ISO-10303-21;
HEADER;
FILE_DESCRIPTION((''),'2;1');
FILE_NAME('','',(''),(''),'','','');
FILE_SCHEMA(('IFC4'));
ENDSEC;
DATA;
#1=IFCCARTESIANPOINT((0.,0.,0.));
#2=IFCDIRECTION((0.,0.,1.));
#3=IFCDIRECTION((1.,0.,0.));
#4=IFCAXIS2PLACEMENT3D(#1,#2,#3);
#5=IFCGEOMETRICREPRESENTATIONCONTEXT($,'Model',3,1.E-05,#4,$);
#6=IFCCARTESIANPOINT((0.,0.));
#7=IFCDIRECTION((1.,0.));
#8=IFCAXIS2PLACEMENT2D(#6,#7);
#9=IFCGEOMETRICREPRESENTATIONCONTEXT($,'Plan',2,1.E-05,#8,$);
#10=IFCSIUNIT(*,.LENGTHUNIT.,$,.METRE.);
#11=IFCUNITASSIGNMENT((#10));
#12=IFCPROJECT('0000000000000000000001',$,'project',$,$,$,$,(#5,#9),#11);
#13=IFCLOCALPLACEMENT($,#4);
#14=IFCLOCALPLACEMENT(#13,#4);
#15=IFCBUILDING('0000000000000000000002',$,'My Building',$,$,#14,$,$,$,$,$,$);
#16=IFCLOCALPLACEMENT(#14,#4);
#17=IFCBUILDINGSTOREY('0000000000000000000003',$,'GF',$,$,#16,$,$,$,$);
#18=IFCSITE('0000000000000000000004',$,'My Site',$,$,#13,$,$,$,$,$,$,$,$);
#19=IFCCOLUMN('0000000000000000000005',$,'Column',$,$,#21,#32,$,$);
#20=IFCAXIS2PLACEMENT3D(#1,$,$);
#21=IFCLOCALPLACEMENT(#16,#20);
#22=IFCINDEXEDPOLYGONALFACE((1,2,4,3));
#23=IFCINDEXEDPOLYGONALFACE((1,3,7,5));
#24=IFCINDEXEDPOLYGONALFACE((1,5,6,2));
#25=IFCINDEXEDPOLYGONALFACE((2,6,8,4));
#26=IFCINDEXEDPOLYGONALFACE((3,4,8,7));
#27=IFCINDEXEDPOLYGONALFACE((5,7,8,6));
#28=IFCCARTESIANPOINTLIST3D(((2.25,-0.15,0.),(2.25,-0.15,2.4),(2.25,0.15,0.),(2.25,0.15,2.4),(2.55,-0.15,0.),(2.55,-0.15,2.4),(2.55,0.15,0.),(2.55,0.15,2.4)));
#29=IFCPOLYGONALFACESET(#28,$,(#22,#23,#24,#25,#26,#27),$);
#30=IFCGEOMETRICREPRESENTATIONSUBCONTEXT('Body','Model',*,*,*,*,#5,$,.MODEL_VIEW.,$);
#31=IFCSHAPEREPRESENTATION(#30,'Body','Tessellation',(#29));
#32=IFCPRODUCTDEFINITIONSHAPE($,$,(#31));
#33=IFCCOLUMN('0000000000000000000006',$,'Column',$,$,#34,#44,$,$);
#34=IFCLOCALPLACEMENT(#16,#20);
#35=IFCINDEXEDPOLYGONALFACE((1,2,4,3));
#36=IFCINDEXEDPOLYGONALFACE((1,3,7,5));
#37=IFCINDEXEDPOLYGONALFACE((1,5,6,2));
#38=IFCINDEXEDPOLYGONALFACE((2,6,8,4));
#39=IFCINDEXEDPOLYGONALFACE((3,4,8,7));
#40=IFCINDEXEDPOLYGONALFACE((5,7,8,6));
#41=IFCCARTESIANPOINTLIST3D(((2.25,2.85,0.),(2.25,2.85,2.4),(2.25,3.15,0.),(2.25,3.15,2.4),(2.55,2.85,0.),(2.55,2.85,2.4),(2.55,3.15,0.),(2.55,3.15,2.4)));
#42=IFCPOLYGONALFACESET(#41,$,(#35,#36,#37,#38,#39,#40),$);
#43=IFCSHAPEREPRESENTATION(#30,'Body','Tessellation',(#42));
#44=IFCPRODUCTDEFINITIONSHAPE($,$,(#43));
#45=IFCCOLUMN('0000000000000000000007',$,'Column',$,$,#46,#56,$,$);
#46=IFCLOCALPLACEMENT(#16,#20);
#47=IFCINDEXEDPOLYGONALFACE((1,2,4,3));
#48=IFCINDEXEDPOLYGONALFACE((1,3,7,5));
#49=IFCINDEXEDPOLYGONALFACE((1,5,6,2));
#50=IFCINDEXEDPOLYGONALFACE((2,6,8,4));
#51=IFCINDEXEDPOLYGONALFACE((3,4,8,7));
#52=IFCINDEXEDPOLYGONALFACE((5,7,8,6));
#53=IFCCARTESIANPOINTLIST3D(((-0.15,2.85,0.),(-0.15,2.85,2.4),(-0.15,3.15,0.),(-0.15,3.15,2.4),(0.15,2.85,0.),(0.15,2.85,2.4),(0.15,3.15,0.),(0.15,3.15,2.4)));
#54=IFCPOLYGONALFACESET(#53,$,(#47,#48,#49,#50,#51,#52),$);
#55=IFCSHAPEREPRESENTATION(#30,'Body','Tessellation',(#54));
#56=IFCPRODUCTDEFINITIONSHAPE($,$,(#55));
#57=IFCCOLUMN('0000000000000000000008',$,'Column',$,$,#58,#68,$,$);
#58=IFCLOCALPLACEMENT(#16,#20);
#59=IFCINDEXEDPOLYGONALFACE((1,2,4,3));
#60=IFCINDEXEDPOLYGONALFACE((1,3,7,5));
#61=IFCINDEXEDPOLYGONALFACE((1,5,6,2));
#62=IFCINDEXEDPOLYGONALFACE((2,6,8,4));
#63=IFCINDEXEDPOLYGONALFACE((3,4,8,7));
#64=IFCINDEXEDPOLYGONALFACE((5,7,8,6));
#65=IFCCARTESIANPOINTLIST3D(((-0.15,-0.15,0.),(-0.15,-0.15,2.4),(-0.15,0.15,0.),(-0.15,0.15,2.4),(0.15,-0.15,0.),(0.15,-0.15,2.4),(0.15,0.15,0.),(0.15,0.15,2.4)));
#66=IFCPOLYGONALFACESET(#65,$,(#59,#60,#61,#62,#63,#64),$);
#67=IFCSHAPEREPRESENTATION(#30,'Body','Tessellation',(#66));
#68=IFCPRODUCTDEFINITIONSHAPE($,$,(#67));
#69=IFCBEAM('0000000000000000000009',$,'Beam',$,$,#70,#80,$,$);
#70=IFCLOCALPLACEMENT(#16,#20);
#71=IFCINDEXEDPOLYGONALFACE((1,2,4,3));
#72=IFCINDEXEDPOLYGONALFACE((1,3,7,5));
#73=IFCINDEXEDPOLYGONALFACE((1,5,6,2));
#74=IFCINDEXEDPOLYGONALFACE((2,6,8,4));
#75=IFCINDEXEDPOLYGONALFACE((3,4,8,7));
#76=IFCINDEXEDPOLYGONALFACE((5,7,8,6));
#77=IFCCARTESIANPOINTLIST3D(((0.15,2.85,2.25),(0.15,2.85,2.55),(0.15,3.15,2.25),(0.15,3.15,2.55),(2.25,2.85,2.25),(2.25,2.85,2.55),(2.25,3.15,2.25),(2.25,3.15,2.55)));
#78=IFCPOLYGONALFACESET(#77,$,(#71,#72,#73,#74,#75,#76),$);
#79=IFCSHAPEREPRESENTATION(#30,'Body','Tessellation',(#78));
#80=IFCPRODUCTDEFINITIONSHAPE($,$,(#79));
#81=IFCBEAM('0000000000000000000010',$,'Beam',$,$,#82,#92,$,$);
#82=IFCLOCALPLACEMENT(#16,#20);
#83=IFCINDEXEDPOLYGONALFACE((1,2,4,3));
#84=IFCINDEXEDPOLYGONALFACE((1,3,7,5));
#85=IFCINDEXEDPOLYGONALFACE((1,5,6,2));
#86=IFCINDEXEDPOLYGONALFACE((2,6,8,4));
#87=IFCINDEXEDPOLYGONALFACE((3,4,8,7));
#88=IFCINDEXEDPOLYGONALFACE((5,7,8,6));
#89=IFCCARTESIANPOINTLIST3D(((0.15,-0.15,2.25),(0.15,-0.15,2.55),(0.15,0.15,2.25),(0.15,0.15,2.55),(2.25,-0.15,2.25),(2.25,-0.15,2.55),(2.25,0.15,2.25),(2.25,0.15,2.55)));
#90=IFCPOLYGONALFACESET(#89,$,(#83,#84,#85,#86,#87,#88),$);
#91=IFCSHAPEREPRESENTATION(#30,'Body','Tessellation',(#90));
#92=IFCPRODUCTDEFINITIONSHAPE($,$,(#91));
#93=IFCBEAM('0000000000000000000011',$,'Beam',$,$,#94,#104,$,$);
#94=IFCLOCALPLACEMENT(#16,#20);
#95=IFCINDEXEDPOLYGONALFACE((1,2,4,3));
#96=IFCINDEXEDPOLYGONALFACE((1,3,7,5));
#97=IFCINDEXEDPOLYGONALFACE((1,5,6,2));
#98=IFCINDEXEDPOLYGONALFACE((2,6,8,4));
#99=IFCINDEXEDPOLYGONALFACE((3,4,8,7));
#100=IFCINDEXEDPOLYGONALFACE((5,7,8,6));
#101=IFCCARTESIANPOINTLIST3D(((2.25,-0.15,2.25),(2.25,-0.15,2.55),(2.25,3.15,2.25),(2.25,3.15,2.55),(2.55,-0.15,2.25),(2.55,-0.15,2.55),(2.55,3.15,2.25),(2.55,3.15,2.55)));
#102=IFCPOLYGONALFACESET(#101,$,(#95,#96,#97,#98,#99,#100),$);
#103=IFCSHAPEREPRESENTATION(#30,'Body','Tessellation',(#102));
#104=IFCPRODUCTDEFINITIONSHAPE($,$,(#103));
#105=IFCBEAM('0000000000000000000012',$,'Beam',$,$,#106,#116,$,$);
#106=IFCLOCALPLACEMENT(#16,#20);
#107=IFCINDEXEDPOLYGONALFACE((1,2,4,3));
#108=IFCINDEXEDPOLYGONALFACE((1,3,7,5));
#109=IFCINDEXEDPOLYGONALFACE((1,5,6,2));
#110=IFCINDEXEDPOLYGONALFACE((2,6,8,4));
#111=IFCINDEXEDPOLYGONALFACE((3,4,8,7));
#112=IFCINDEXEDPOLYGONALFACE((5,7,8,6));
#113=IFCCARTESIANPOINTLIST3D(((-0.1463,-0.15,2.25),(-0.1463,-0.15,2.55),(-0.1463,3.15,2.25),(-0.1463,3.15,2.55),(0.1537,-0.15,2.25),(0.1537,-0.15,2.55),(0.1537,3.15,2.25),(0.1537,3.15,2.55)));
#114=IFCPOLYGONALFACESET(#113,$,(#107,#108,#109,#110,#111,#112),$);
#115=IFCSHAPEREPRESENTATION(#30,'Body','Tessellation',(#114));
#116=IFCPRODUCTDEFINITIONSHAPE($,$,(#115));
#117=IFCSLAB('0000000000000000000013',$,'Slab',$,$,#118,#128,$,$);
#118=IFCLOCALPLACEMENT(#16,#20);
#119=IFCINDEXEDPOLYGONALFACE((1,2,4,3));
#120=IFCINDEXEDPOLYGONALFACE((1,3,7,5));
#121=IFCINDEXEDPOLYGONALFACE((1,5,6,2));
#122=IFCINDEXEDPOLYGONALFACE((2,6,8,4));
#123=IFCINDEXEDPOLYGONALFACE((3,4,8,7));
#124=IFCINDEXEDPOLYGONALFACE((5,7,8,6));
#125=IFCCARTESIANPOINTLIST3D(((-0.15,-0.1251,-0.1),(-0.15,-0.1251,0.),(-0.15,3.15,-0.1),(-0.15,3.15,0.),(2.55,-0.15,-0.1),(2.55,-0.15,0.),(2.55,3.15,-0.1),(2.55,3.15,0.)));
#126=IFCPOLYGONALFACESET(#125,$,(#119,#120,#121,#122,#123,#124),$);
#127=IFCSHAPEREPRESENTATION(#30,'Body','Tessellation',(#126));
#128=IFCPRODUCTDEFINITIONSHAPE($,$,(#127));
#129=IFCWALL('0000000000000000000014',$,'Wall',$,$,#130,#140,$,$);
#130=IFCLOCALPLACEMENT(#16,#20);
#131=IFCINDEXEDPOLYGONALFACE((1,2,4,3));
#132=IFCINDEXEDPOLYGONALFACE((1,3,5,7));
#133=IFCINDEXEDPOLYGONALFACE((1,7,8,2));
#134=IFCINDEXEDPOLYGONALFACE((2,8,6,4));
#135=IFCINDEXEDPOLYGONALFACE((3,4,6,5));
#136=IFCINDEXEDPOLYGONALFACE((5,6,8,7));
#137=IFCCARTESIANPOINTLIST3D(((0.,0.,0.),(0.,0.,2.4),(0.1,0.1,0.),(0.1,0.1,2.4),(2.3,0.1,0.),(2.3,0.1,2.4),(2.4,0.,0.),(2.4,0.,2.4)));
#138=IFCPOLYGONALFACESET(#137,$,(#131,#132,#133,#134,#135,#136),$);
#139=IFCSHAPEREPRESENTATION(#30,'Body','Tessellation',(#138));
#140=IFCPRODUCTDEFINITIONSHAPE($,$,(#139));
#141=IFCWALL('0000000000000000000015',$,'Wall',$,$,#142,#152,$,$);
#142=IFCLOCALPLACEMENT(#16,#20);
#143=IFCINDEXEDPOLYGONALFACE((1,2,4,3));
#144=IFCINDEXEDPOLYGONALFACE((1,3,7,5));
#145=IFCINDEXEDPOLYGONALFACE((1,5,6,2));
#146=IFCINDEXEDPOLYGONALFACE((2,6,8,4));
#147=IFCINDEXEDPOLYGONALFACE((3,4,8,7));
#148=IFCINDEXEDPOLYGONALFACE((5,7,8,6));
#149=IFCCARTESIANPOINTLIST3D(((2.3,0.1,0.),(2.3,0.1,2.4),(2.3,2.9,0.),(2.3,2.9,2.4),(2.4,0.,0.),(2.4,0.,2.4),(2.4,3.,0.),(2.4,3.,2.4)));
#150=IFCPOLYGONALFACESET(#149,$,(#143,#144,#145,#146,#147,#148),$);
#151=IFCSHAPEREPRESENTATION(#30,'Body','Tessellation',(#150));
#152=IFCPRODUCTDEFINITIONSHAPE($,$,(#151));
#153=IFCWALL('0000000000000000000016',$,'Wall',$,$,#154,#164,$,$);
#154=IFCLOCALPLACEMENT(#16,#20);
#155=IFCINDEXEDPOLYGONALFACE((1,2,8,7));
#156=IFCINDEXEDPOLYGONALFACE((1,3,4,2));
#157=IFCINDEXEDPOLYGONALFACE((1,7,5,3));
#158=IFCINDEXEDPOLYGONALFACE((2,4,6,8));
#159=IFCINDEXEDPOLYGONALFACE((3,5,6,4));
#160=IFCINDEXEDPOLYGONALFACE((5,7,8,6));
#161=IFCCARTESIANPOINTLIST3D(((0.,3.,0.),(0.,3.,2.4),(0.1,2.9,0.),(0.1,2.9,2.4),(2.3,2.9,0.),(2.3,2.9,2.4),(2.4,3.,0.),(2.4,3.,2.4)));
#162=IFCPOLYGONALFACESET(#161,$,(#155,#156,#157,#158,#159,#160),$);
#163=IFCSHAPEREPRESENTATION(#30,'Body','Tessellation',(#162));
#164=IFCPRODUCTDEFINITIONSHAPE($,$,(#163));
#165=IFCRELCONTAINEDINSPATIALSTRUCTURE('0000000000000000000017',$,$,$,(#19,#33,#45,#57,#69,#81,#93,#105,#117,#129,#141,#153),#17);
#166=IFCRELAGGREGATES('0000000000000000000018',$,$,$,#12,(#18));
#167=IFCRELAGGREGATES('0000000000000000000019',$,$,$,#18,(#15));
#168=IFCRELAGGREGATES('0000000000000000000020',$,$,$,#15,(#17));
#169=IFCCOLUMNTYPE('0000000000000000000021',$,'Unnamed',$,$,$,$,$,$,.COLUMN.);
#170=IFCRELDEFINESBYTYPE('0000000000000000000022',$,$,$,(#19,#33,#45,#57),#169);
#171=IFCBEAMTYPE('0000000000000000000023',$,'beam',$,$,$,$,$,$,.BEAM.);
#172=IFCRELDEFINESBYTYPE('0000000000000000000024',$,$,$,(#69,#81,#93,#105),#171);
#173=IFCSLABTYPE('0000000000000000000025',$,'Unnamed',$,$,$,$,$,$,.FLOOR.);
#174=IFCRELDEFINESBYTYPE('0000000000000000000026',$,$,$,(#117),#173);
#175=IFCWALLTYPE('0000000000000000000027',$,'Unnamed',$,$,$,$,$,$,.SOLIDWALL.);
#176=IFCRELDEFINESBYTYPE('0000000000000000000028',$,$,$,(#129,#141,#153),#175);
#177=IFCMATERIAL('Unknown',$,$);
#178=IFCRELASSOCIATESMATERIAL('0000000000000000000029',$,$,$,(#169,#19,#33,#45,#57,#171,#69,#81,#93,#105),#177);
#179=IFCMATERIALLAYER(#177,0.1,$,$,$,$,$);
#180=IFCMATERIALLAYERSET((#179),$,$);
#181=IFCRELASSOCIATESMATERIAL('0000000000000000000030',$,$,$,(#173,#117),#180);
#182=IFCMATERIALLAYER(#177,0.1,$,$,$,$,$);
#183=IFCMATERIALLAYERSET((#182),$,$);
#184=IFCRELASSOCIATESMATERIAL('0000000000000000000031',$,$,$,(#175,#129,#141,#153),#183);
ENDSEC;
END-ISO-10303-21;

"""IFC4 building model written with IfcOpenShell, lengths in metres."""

from ifc_helpers import new_model, si_unit, frame, origin_with_axes, origin_2d_with_axis, place, context, subcontext, project, spatial, line, indexed_curve, outline, extrude, material, layer, layer_set, layer_usage, material_profile, profile_set, profile_usage, type_object, element, save


model = new_model("IFC4")

# Units and contexts
model_context = context("Model", 3, precision=1e-05, world=origin_with_axes())
plan_context = context("Plan", 2, precision=1e-05, world=origin_2d_with_axis())
body_context_1 = subcontext(model_context, "Body", "Model", "MODEL_VIEW")
ifc_project = project(units=[si_unit("LENGTHUNIT", "METRE")], contexts=[model_context, plan_context])

# Site, building, storey
site_placement = place(None, origin_with_axes())
site = spatial("IfcSite", under=ifc_project, at=site_placement, Name="My Site")
building_placement = place(site_placement, origin_with_axes())
building = spatial("IfcBuilding", under=site, at=building_placement, Name="My Building")
storey_placement = place(building_placement, origin_with_axes())
storey = spatial("IfcBuildingStorey", under=building, at=storey_placement, Name="GF")

# Columns
ifc_material = material(Name="Unknown")
ifc_material_profile_1 = material_profile(ifc_material, outline(indexed_curve([(-0.15, 0.15), (0.15, 0.15), (0.15, -0.15), (-0.15, -0.15), (-0.15, 0.15)])))
ifc_profile_set_1 = profile_set([ifc_material_profile_1])
ifc_profile_usage_1 = profile_usage(ifc_profile_set_1, cardinal=5)
column_type = type_object("IfcColumnType", Name="Unnamed", PredefinedType="COLUMN", material=ifc_profile_set_1)
column_1_placement = place(storey_placement, frame((2.4, 0.0, 0.0), z_axis=(0.0, 0.0, 1.0), x_axis=(1.0, 0.0, 0.0)))
element("IfcColumn", 1, at=column_1_placement, inside=storey, type_object=column_type, material=ifc_profile_usage_1, Name="Column", context=body_context_1, shape_type="SweptSolid", body=[
    extrude(outline(indexed_curve([(-0.15, 0.15), (0.15, 0.15), (0.15, -0.15), (-0.15, -0.15), (-0.15, 0.15)])), origin_with_axes(), (0.0, 0.0, 1.0), 2.4),
])
ifc_profile_usage_2 = profile_usage(ifc_profile_set_1, cardinal=5)
column_2_placement = place(storey_placement, frame((2.4, 3.0, 0.0), z_axis=(0.0, 0.0, 1.0), x_axis=(1.0, 0.0, 0.0)))
element("IfcColumn", 2, at=column_2_placement, inside=storey, type_object=column_type, material=ifc_profile_usage_2, Name="Column", context=body_context_1, shape_type="SweptSolid", body=[
    extrude(outline(indexed_curve([(-0.15, 0.15), (0.15, 0.15), (0.15, -0.15), (-0.15, -0.15), (-0.15, 0.15)])), origin_with_axes(), (0.0, 0.0, 1.0), 2.4),
])
ifc_profile_usage_3 = profile_usage(ifc_profile_set_1, cardinal=5)
column_3_placement = place(storey_placement, frame((0.0, 3.0, 0.0), z_axis=(0.0, 0.0, 1.0), x_axis=(1.0, 0.0, 0.0)))
element("IfcColumn", 3, at=column_3_placement, inside=storey, type_object=column_type, material=ifc_profile_usage_3, Name="Column", context=body_context_1, shape_type="SweptSolid", body=[
    extrude(outline(indexed_curve([(-0.15, 0.15), (0.15, 0.15), (0.15, -0.15), (-0.15, -0.15), (-0.15, 0.15)])), origin_with_axes(), (0.0, 0.0, 1.0), 2.4),
])
ifc_profile_usage_4 = profile_usage(ifc_profile_set_1, cardinal=5)
column_4_placement = place(storey_placement, frame((0.0, 0.0, 0.0), z_axis=(0.0, 0.0, 1.0), x_axis=(1.0, 0.0, 0.0)))
element("IfcColumn", 4, at=column_4_placement, inside=storey, type_object=column_type, material=ifc_profile_usage_4, Name="Column", context=body_context_1, shape_type="SweptSolid", body=[
    extrude(outline(indexed_curve([(-0.15, 0.15), (0.15, 0.15), (0.15, -0.15), (-0.15, -0.15), (-0.15, 0.15)])), origin_with_axes(), (0.0, 0.0, 1.0), 2.4),
])

# Beams
ifc_material_profile_2 = material_profile(ifc_material, outline(indexed_curve([(-0.15, 0.15), (0.15, 0.15), (0.15, -0.15), (-0.15, -0.15), (-0.15, 0.15)])))
ifc_profile_set_2 = profile_set([ifc_material_profile_2])
ifc_profile_usage_5 = profile_usage(ifc_profile_set_2, cardinal=5)
beam_type = type_object("IfcBeamType", Name="beam", PredefinedType="BEAM", material=ifc_profile_set_2)
beam_1_placement = place(storey_placement, frame((2.25, 3.0, 2.4), z_axis=(-1.0, -0.000001, 0.0), x_axis=(0.000001, -1.0, 0.0)))
element("IfcBeam", 5, at=beam_1_placement, inside=storey, type_object=beam_type, material=ifc_profile_usage_5, Name="Beam", context=body_context_1, shape_type="SweptSolid", body=[
    extrude(outline(indexed_curve([(-0.15, 0.15), (0.15, 0.15), (0.15, -0.15), (-0.15, -0.15), (-0.15, 0.15)])), origin_with_axes(), (0.0, 0.0, 1.0), 2.1),
])
ifc_profile_usage_6 = profile_usage(ifc_profile_set_2, cardinal=5)
beam_2_placement = place(storey_placement, frame((0.15, 0.0, 2.4), z_axis=(1.0, 0.0, 0.0), x_axis=(0.0, 1.0, 0.0)))
element("IfcBeam", 6, at=beam_2_placement, inside=storey, type_object=beam_type, material=ifc_profile_usage_6, Name="Beam", context=body_context_1, shape_type="SweptSolid", body=[
    extrude(outline(indexed_curve([(-0.15, 0.15), (0.15, 0.15), (0.15, -0.15), (-0.15, -0.15), (-0.15, 0.15)])), origin_with_axes(), (0.0, 0.0, 1.0), 2.1),
])
ifc_profile_usage_7 = profile_usage(ifc_profile_set_2, cardinal=5)
beam_3_placement = place(storey_placement, frame((2.4, -0.15, 2.4), z_axis=(0.0, 1.0, 0.0), x_axis=(-1.0, 0.0, 0.0)))
element("IfcBeam", 7, at=beam_3_placement, inside=storey, type_object=beam_type, material=ifc_profile_usage_7, Name="Beam", context=body_context_1, shape_type="SweptSolid", body=[
    extrude(outline(indexed_curve([(-0.15, 0.15), (0.15, 0.15), (0.15, -0.15), (-0.15, -0.15), (-0.15, 0.15)])), origin_with_axes(), (0.0, 0.0, 1.0), 3.3),
])
ifc_profile_usage_8 = profile_usage(ifc_profile_set_2, cardinal=5)
beam_4_placement = place(storey_placement, frame((0.0037, -0.15, 2.4), z_axis=(0.0, 1.0, 0.0), x_axis=(-1.0, 0.0, 0.0)))
element("IfcBeam", 8, at=beam_4_placement, inside=storey, type_object=beam_type, material=ifc_profile_usage_8, Name="Beam", context=body_context_1, shape_type="SweptSolid", body=[
    extrude(outline(indexed_curve([(-0.15, 0.15), (0.15, 0.15), (0.15, -0.15), (-0.15, -0.15), (-0.15, 0.15)])), origin_with_axes(), (0.0, 0.0, 1.0), 3.3),
])

# Slab
ifc_layer_1 = layer(ifc_material, 0.1)
ifc_layer_set_1 = layer_set([ifc_layer_1])
ifc_layer_usage_1 = layer_usage(ifc_layer_set_1, "AXIS3", "POSITIVE", -0.1)
slab_type = type_object("IfcSlabType", Name="Unnamed", PredefinedType="FLOOR", material=ifc_layer_set_1)
slab_1_placement = place(storey_placement, frame((-0.15, 3.15, 0.0), z_axis=(0.0, 0.0, 1.0), x_axis=(1.0, 0.0, 0.0)))
element("IfcSlab", 9, at=slab_1_placement, inside=storey, type_object=slab_type, material=ifc_layer_usage_1, Name="Slab", context=body_context_1, shape_type="SweptSolid", body=[
    extrude(outline(indexed_curve([(0.0, 0.0), (0.0, -3.2751), (2.7, -3.3), (2.7, 0.0), (0.0, 0.0)])), frame((0.0, 0.0, -0.1), z_axis=(0.0, 0.0, 1.0), x_axis=(1.0, 0.0, 0.0)), (0.0, 0.0, 1.0), 0.1),
])

# Walls
ifc_layer_2 = layer(ifc_material, 0.1)
ifc_layer_set_2 = layer_set([ifc_layer_2])
ifc_layer_usage_2 = layer_usage(ifc_layer_set_2, "AXIS2", "POSITIVE", 0.0)
wall_type = type_object("IfcWallType", Name="Unnamed", PredefinedType="SOLIDWALL", material=ifc_layer_set_2)
wall_1_placement = place(storey_placement, frame((0.0, 0.0, 0.0), z_axis=(0.0, 0.0, 1.0), x_axis=(1.0, 0.0, 0.0)))
element("IfcWall", 10, at=wall_1_placement, inside=storey, type_object=wall_type, material=ifc_layer_usage_2, Name="Wall", context=body_context_1, shape_type="SweptSolid", body=[
    extrude(outline(indexed_curve([(0.0, 0.0), (0.1, 0.1), (2.3, 0.1), (2.4, 0.0)], segments=[line(1, 2, 3, 4, 1)])), origin_with_axes(), (0.0, 0.0, 1.0), 2.4),
])
ifc_layer_usage_3 = layer_usage(ifc_layer_set_2, "AXIS2", "POSITIVE", 0.0)
wall_2_placement = place(storey_placement, frame((2.4, 0.0, 0.0), z_axis=(0.0, 0.0, 1.0), x_axis=(0.0, 1.0, 0.0)))
element("IfcWall", 11, at=wall_2_placement, inside=storey, type_object=wall_type, material=ifc_layer_usage_3, Name="Wall", context=body_context_1, shape_type="SweptSolid", body=[
    extrude(outline(indexed_curve([(0.0, 0.0), (0.1, 0.1), (2.9, 0.1), (3.0, 0.0)], segments=[line(1, 2, 3, 4, 1)])), origin_with_axes(), (0.0, 0.0, 1.0), 2.4),
])
ifc_layer_usage_4 = layer_usage(ifc_layer_set_2, "AXIS2", "POSITIVE", 0.0)
wall_3_placement = place(storey_placement, frame((2.4, 3.0, 0.0), z_axis=(0.0, 0.0, 1.0), x_axis=(-1.0, 0.0, 0.0)))
element("IfcWall", 12, at=wall_3_placement, inside=storey, type_object=wall_type, material=ifc_layer_usage_4, Name="Wall", context=body_context_1, shape_type="SweptSolid", body=[
    extrude(outline(indexed_curve([(0.0, 0.0), (0.1, 0.1), (2.3, 0.1), (2.4, 0.0)], segments=[line(1, 2, 3, 4, 1)])), origin_with_axes(), (0.0, 0.0, 1.0), 2.4),
])

save(model, "model.ifc")
